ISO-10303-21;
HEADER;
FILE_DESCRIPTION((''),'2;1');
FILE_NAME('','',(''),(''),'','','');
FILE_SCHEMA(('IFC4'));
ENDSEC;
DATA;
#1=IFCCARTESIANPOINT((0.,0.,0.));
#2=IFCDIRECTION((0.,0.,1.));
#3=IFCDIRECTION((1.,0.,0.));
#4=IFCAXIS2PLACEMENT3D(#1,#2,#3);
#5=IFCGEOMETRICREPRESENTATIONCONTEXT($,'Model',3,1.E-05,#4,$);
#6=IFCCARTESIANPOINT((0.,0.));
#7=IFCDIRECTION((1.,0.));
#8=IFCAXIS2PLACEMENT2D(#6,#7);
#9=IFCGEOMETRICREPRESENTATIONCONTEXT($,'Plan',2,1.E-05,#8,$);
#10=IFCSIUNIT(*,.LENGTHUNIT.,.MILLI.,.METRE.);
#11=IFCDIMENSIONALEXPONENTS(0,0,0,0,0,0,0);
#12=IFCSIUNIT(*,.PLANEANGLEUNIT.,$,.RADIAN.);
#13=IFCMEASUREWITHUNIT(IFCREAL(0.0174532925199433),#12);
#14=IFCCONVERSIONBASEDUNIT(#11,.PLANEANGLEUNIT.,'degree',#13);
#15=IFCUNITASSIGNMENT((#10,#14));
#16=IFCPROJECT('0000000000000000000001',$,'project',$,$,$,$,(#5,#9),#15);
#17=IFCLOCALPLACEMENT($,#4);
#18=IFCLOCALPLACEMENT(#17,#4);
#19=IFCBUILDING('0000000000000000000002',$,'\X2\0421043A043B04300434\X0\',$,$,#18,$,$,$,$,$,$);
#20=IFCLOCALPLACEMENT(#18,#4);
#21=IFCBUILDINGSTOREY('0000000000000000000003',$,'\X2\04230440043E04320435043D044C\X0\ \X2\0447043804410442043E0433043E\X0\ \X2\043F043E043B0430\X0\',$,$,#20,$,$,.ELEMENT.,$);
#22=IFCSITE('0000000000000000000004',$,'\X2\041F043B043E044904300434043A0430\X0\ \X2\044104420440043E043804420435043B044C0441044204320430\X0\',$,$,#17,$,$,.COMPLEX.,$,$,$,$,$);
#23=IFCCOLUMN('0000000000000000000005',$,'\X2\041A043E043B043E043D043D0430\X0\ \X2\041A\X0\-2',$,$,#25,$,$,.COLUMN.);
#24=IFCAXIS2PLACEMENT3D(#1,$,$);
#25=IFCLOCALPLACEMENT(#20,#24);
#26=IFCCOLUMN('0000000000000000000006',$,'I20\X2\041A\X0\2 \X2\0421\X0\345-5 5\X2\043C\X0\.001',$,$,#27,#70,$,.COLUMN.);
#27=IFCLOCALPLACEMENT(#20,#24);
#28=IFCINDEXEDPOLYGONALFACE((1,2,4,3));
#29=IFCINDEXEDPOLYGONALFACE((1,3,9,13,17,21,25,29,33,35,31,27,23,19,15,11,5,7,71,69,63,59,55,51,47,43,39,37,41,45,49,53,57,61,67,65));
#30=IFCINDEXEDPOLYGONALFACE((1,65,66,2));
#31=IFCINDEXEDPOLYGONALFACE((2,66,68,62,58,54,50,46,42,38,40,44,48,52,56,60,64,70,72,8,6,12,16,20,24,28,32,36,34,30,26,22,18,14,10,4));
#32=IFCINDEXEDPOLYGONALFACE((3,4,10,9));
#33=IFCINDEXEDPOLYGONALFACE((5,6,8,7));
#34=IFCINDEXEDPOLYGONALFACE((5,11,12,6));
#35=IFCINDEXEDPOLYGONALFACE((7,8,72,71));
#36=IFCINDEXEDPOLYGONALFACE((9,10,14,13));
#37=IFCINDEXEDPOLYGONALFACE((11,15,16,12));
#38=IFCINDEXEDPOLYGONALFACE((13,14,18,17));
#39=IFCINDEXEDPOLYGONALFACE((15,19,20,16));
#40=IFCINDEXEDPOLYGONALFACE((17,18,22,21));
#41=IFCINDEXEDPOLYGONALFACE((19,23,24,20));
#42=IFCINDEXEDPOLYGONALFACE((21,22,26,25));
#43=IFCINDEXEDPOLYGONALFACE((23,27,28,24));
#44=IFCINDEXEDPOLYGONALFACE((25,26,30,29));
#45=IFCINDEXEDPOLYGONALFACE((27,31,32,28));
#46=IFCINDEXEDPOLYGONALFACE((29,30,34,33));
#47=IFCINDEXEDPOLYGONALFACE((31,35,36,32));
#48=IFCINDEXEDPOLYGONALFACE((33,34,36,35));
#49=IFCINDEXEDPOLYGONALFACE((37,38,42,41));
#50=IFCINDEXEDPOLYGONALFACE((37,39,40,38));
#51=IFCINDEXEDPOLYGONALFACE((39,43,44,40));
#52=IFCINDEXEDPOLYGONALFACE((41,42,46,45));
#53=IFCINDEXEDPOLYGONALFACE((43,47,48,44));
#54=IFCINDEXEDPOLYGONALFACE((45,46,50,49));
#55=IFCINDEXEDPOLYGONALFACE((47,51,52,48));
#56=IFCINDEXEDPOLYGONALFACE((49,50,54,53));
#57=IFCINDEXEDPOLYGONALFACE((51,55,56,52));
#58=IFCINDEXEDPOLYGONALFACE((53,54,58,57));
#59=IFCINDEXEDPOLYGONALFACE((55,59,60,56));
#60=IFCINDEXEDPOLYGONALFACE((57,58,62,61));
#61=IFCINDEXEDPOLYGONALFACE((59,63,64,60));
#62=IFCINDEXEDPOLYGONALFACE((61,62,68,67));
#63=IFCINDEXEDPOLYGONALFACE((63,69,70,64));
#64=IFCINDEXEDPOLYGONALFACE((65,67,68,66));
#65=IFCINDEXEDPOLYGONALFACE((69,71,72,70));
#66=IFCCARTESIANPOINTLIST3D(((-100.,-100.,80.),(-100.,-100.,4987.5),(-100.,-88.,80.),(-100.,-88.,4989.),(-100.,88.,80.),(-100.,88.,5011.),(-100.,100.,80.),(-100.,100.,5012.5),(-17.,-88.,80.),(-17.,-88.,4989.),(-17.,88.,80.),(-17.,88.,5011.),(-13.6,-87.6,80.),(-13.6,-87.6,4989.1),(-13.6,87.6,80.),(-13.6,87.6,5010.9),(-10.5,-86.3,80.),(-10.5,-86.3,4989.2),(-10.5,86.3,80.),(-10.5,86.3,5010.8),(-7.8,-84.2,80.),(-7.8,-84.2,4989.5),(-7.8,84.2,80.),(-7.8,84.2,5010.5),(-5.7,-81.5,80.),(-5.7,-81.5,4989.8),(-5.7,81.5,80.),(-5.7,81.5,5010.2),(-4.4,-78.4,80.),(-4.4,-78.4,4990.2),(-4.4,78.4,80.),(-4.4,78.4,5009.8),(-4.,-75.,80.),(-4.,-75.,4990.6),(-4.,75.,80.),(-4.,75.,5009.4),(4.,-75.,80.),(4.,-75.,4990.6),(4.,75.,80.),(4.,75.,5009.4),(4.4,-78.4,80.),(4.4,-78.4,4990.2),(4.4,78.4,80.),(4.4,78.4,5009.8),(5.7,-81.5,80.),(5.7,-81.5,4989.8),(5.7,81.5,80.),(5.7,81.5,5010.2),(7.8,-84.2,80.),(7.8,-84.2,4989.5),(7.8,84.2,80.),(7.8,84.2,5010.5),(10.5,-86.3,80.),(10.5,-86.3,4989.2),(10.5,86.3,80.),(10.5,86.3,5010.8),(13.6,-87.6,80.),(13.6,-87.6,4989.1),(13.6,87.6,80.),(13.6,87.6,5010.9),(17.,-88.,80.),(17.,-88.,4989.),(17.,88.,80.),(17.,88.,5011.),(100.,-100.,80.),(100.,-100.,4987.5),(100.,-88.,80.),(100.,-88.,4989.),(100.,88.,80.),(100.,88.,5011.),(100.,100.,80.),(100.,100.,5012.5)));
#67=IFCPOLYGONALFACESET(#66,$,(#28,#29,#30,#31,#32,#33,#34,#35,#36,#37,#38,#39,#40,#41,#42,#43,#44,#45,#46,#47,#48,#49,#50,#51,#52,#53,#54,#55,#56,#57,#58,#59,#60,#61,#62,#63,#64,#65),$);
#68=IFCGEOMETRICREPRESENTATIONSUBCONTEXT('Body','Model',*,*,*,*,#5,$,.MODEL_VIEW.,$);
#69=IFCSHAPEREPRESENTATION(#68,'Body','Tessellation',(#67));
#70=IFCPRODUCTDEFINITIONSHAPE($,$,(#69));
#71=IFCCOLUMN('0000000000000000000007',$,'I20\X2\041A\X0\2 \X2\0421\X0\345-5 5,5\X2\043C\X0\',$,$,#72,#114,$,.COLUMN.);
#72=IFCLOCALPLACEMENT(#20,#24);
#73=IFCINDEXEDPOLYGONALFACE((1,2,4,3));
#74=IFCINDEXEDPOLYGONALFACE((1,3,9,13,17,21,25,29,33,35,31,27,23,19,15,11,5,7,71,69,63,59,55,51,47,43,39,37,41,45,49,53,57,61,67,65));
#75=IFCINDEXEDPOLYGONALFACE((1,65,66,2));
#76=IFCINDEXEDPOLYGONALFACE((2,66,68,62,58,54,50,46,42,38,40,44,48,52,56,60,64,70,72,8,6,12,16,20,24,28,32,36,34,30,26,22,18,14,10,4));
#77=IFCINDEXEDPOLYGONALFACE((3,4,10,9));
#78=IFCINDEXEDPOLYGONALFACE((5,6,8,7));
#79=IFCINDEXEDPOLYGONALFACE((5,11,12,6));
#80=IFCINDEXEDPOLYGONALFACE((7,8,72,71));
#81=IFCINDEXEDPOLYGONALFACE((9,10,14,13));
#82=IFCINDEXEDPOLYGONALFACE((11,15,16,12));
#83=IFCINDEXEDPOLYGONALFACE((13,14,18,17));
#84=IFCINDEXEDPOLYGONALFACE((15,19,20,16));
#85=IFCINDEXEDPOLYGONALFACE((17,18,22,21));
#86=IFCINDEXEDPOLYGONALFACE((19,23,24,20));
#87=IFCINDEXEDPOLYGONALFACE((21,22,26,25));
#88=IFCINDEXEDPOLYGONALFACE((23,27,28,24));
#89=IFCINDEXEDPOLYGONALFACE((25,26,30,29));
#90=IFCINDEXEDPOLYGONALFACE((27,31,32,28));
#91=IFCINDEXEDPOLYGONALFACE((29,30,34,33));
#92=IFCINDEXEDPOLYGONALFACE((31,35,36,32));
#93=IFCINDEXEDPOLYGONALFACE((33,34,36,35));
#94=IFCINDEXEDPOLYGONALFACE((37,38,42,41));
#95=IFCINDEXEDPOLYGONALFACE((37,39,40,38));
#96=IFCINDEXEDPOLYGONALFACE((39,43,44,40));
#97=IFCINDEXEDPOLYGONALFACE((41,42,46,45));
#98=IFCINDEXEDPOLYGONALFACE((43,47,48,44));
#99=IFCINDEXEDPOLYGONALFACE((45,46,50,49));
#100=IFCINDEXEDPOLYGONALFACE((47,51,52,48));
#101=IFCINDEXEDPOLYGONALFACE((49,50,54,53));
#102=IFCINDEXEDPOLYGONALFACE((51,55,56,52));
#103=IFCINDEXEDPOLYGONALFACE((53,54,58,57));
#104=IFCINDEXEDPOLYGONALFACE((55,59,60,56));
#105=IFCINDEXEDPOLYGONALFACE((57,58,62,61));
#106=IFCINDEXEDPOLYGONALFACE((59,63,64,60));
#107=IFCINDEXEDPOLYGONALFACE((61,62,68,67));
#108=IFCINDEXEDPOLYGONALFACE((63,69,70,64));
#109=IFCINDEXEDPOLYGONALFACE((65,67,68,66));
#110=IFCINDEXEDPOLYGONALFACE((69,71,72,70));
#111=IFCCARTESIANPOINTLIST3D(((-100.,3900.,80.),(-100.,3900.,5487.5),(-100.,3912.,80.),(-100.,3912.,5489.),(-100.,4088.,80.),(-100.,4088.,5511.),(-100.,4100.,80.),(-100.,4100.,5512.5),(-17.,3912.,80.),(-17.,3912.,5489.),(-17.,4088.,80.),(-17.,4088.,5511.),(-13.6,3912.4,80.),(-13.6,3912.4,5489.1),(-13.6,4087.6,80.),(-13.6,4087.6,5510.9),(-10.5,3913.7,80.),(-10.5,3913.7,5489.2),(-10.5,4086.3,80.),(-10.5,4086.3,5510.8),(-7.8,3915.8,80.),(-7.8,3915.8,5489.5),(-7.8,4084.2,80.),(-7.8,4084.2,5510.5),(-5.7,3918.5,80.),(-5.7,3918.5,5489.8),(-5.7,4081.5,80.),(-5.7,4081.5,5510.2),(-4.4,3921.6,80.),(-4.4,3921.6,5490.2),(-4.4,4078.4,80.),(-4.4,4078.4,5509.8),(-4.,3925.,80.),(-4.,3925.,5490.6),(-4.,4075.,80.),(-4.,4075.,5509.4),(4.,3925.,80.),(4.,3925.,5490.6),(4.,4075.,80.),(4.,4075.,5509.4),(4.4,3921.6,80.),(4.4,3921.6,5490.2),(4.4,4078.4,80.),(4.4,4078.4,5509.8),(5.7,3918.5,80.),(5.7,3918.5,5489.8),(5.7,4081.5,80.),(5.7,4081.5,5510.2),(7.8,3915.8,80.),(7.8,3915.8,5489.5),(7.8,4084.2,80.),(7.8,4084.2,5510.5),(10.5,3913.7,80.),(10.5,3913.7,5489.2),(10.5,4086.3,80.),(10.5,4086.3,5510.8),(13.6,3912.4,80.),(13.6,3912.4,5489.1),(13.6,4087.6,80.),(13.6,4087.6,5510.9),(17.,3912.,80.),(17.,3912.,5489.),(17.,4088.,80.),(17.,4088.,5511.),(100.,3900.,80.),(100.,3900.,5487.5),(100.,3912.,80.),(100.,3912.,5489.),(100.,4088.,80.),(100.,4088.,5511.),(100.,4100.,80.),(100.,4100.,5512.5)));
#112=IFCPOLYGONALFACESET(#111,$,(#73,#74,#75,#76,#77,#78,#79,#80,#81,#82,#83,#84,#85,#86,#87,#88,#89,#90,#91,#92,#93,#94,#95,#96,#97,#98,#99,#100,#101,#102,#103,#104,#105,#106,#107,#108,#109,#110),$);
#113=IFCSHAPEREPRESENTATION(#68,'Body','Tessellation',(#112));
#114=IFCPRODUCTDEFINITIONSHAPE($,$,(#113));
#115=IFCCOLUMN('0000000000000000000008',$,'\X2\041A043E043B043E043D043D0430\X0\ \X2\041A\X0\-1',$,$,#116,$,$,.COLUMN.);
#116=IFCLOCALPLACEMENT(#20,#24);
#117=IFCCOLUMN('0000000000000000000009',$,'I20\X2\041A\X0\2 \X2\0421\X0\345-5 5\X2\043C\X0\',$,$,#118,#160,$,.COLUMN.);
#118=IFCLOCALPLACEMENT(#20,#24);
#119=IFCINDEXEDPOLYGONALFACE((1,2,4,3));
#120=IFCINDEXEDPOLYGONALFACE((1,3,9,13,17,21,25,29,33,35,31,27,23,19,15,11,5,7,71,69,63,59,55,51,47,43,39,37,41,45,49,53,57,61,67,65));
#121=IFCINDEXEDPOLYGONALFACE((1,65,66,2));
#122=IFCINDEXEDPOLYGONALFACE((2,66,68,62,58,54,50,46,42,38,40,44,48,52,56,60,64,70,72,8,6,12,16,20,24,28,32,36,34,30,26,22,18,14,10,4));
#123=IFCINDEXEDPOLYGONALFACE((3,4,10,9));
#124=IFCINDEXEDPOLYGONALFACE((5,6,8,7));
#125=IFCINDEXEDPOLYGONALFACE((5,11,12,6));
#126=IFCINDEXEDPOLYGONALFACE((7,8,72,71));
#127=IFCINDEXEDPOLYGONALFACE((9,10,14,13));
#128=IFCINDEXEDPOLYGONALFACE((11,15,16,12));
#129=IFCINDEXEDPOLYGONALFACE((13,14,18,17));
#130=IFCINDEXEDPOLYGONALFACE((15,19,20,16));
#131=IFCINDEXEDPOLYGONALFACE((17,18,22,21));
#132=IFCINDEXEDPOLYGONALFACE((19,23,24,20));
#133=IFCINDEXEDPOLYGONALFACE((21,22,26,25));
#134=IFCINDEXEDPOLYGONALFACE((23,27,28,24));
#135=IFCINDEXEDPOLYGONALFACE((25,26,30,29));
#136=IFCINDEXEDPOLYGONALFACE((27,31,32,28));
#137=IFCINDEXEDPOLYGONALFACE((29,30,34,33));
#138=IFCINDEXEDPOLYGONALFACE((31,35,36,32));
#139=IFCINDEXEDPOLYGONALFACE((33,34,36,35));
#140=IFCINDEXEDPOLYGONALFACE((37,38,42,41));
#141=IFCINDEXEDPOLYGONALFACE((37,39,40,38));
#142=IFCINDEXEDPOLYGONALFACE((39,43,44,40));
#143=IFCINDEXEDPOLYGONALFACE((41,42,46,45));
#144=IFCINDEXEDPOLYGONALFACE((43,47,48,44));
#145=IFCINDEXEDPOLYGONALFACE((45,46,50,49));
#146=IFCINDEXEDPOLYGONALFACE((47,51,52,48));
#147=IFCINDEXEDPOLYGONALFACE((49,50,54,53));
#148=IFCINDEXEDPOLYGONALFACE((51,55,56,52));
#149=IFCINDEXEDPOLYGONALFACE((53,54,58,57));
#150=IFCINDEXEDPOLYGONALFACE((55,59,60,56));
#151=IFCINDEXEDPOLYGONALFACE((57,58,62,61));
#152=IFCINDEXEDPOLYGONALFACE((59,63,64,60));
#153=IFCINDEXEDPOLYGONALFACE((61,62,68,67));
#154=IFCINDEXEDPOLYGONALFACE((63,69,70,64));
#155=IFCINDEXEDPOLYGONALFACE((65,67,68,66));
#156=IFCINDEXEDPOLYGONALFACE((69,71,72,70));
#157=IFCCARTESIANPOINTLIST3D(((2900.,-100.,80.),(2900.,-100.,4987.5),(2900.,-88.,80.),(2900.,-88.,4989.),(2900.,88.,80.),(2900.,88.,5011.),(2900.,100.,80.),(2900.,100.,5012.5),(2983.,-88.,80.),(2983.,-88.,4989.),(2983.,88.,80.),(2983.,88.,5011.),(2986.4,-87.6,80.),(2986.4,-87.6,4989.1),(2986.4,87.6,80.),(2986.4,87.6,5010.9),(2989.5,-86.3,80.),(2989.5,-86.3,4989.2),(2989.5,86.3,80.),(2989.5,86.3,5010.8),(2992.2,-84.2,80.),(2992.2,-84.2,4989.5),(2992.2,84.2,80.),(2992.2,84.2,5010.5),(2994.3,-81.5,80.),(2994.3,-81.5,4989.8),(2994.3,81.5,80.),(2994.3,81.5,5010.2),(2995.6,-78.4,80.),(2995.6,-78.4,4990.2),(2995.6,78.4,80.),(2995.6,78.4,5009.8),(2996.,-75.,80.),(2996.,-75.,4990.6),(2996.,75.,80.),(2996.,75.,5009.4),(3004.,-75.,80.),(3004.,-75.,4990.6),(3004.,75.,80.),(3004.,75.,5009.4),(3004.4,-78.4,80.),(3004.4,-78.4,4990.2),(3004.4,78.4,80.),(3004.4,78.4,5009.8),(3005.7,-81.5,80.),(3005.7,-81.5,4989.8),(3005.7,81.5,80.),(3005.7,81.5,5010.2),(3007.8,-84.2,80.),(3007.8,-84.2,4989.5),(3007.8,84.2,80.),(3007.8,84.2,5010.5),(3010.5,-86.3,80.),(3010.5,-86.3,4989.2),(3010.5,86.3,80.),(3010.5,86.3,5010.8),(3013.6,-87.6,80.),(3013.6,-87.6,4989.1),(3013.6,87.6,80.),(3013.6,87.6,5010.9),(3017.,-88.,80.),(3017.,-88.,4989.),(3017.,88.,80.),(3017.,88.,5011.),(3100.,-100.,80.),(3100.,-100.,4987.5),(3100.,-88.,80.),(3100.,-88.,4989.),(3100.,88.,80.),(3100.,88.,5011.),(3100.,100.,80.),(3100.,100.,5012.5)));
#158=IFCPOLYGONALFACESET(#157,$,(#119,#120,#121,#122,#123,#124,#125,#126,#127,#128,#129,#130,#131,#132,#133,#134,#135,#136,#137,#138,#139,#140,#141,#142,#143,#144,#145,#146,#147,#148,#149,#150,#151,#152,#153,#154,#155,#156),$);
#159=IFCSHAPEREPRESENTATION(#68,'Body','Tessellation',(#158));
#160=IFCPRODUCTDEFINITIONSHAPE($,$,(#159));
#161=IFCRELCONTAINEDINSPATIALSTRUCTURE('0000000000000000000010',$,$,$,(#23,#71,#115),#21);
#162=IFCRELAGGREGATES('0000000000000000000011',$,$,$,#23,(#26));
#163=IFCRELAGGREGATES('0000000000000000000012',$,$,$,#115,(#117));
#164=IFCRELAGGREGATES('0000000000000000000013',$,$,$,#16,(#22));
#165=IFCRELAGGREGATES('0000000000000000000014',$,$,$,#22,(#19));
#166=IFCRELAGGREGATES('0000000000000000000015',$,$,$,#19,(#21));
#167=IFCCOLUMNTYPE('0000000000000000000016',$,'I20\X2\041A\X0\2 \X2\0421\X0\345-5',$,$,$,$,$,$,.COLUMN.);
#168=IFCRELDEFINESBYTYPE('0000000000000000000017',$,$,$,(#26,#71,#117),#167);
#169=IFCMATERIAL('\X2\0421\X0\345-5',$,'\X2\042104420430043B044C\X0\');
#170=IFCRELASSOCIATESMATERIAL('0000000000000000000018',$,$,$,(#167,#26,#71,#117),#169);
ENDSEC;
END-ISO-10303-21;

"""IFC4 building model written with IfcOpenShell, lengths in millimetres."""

from ifc_helpers import new_model, entity, si_unit, converted_unit, frame, origin_with_axes, origin_2d_with_axis, place, context, subcontext, project, spatial, i_section, extrude, boolean, clip, halfspace, material, material_profile, profile_set, profile_usage, type_object, element, aggregate, save


model = new_model("IFC4")

# Units and contexts
model_context = context("Model", 3, precision=1e-05, world=origin_with_axes())
plan_context = context("Plan", 2, precision=1e-05, world=origin_2d_with_axis())
body_context = subcontext(model_context, "Body", "Model", "MODEL_VIEW")
ifc_project = project(units=[si_unit("LENGTHUNIT", "METRE", prefix="MILLI"), converted_unit("PLANEANGLEUNIT", "degree", entity("IfcReal", 0.0174532925199433), si_unit("PLANEANGLEUNIT", "RADIAN"), dimensions=[0, 0, 0, 0, 0, 0, 0])], contexts=[model_context, plan_context])

# Site, building, storey
site_placement = place(None, origin_with_axes())
site = spatial("IfcSite", under=ifc_project, at=site_placement, Name="Площадка строительства", CompositionType="COMPLEX")
building_placement = place(site_placement, origin_with_axes())
building = spatial("IfcBuilding", under=site, at=building_placement, Name="Склад")
storey_placement = place(building_placement, origin_with_axes())
storey = spatial("IfcBuildingStorey", under=building, at=storey_placement, Name="Уровень чистого пола", CompositionType="ELEMENT")

# Columns
column_1_placement = place(storey_placement, origin_with_axes())
column_1 = element("IfcColumn", 1, at=column_1_placement, inside=storey, Name="Колонна К-2", PredefinedType="COLUMN")
ifc_material_1 = material(Name="С345-5", Category="Сталь")
ifc_material_profile_1 = material_profile(ifc_material_1, i_section(OverallWidth=200.0, OverallDepth=200.0, WebThickness=8.0, FlangeThickness=12.0, FilletRadius=13.0, FlangeEdgeRadius=0.0, FlangeSlope=0.0))
ifc_profile_set_1 = profile_set([ifc_material_profile_1], Name="I20К2_С345-5")
ifc_profile_usage_1 = profile_usage(ifc_profile_set_1, cardinal=5)
column_type = type_object("IfcColumnType", Name="I20К2 С345-5", PredefinedType="COLUMN", material=ifc_profile_set_1)
column_2_placement = place(column_1_placement, origin_with_axes())
column_2 = element("IfcColumn", 2, at=column_2_placement, type_object=column_type, material=ifc_profile_usage_1, Name="I20К2 С345-5 5м.001", PredefinedType="COLUMN", context=body_context, shape_type="Clipping", body=[
    boolean("DIFFERENCE", clip(extrude(i_section(OverallWidth=200.0, OverallDepth=200.0, WebThickness=8.0, FlangeThickness=12.0, FilletRadius=13.0, FlangeEdgeRadius=0.0, FlangeSlope=0.0), origin_with_axes(), (0.0, 0.0, 1.0), 5200.0), halfspace(frame((0.0, -298.5, 4962.7), z_axis=(0.0, -0.124035, 0.992278), x_axis=(0.0, 0.992278, 0.124035)), False)), halfspace(frame((0.0, 0.0, 80.0), z_axis=(0.0, 0.0, -1.0), x_axis=(1.0, 0.0, 0.0)), False)),
])

# Column
ifc_profile_usage_2 = profile_usage(ifc_profile_set_1, cardinal=5)
column_3_placement = place(storey_placement, frame((0.0, 4000.0, 0.0), z_axis=(0.0, 0.0, 1.0), x_axis=(1.0, 0.0, 0.0)))
element("IfcColumn", 3, at=column_3_placement, inside=storey, type_object=column_type, material=ifc_profile_usage_2, Name="I20К2 С345-5 5,5м", PredefinedType="COLUMN", context=body_context, shape_type="Clipping", body=[
    boolean("DIFFERENCE", clip(extrude(i_section(OverallWidth=200.0, OverallDepth=200.0, WebThickness=8.0, FlangeThickness=12.0, FilletRadius=13.0, FlangeEdgeRadius=0.0, FlangeSlope=0.0), origin_with_axes(), (0.0, 0.0, 1.0), 5700.0), halfspace(frame((0.0, -4298.5, 4962.7), z_axis=(0.0, -0.124035, 0.992278), x_axis=(0.0, 0.992278, 0.124035)), False)), halfspace(frame((0.0, 0.0, 80.0), z_axis=(0.0, 0.0, -1.0), x_axis=(1.0, 0.0, 0.0)), False)),
])

# Columns
column_4_placement = place(storey_placement, origin_with_axes())
column_4 = element("IfcColumn", 4, at=column_4_placement, inside=storey, Name="Колонна К-1", PredefinedType="COLUMN")
ifc_profile_usage_3 = profile_usage(ifc_profile_set_1, cardinal=5)
column_5_placement = place(column_4_placement, frame((3000.0, 0.0, 0.0), z_axis=(0.0, 0.0, 1.0), x_axis=(1.0, 0.0, 0.0)))
column_5 = element("IfcColumn", 5, at=column_5_placement, type_object=column_type, material=ifc_profile_usage_3, Name="I20К2 С345-5 5м", PredefinedType="COLUMN", context=body_context, shape_type="Clipping", body=[
    boolean("DIFFERENCE", clip(extrude(i_section(OverallWidth=200.0, OverallDepth=200.0, WebThickness=8.0, FlangeThickness=12.0, FilletRadius=13.0, FlangeEdgeRadius=0.0, FlangeSlope=0.0), origin_with_axes(), (0.0, 0.0, 1.0), 5200.0), halfspace(frame((0.0, -298.5, 4962.7), z_axis=(0.0, -0.124035, 0.992278), x_axis=(0.0, 0.992278, 0.124035)), False)), halfspace(frame((0.0, 0.0, 80.0), z_axis=(0.0, 0.0, -1.0), x_axis=(1.0, 0.0, 0.0)), False)),
])

aggregate(column_1, [column_2])
aggregate(column_4, [column_5])

save(model, "model.ifc")
